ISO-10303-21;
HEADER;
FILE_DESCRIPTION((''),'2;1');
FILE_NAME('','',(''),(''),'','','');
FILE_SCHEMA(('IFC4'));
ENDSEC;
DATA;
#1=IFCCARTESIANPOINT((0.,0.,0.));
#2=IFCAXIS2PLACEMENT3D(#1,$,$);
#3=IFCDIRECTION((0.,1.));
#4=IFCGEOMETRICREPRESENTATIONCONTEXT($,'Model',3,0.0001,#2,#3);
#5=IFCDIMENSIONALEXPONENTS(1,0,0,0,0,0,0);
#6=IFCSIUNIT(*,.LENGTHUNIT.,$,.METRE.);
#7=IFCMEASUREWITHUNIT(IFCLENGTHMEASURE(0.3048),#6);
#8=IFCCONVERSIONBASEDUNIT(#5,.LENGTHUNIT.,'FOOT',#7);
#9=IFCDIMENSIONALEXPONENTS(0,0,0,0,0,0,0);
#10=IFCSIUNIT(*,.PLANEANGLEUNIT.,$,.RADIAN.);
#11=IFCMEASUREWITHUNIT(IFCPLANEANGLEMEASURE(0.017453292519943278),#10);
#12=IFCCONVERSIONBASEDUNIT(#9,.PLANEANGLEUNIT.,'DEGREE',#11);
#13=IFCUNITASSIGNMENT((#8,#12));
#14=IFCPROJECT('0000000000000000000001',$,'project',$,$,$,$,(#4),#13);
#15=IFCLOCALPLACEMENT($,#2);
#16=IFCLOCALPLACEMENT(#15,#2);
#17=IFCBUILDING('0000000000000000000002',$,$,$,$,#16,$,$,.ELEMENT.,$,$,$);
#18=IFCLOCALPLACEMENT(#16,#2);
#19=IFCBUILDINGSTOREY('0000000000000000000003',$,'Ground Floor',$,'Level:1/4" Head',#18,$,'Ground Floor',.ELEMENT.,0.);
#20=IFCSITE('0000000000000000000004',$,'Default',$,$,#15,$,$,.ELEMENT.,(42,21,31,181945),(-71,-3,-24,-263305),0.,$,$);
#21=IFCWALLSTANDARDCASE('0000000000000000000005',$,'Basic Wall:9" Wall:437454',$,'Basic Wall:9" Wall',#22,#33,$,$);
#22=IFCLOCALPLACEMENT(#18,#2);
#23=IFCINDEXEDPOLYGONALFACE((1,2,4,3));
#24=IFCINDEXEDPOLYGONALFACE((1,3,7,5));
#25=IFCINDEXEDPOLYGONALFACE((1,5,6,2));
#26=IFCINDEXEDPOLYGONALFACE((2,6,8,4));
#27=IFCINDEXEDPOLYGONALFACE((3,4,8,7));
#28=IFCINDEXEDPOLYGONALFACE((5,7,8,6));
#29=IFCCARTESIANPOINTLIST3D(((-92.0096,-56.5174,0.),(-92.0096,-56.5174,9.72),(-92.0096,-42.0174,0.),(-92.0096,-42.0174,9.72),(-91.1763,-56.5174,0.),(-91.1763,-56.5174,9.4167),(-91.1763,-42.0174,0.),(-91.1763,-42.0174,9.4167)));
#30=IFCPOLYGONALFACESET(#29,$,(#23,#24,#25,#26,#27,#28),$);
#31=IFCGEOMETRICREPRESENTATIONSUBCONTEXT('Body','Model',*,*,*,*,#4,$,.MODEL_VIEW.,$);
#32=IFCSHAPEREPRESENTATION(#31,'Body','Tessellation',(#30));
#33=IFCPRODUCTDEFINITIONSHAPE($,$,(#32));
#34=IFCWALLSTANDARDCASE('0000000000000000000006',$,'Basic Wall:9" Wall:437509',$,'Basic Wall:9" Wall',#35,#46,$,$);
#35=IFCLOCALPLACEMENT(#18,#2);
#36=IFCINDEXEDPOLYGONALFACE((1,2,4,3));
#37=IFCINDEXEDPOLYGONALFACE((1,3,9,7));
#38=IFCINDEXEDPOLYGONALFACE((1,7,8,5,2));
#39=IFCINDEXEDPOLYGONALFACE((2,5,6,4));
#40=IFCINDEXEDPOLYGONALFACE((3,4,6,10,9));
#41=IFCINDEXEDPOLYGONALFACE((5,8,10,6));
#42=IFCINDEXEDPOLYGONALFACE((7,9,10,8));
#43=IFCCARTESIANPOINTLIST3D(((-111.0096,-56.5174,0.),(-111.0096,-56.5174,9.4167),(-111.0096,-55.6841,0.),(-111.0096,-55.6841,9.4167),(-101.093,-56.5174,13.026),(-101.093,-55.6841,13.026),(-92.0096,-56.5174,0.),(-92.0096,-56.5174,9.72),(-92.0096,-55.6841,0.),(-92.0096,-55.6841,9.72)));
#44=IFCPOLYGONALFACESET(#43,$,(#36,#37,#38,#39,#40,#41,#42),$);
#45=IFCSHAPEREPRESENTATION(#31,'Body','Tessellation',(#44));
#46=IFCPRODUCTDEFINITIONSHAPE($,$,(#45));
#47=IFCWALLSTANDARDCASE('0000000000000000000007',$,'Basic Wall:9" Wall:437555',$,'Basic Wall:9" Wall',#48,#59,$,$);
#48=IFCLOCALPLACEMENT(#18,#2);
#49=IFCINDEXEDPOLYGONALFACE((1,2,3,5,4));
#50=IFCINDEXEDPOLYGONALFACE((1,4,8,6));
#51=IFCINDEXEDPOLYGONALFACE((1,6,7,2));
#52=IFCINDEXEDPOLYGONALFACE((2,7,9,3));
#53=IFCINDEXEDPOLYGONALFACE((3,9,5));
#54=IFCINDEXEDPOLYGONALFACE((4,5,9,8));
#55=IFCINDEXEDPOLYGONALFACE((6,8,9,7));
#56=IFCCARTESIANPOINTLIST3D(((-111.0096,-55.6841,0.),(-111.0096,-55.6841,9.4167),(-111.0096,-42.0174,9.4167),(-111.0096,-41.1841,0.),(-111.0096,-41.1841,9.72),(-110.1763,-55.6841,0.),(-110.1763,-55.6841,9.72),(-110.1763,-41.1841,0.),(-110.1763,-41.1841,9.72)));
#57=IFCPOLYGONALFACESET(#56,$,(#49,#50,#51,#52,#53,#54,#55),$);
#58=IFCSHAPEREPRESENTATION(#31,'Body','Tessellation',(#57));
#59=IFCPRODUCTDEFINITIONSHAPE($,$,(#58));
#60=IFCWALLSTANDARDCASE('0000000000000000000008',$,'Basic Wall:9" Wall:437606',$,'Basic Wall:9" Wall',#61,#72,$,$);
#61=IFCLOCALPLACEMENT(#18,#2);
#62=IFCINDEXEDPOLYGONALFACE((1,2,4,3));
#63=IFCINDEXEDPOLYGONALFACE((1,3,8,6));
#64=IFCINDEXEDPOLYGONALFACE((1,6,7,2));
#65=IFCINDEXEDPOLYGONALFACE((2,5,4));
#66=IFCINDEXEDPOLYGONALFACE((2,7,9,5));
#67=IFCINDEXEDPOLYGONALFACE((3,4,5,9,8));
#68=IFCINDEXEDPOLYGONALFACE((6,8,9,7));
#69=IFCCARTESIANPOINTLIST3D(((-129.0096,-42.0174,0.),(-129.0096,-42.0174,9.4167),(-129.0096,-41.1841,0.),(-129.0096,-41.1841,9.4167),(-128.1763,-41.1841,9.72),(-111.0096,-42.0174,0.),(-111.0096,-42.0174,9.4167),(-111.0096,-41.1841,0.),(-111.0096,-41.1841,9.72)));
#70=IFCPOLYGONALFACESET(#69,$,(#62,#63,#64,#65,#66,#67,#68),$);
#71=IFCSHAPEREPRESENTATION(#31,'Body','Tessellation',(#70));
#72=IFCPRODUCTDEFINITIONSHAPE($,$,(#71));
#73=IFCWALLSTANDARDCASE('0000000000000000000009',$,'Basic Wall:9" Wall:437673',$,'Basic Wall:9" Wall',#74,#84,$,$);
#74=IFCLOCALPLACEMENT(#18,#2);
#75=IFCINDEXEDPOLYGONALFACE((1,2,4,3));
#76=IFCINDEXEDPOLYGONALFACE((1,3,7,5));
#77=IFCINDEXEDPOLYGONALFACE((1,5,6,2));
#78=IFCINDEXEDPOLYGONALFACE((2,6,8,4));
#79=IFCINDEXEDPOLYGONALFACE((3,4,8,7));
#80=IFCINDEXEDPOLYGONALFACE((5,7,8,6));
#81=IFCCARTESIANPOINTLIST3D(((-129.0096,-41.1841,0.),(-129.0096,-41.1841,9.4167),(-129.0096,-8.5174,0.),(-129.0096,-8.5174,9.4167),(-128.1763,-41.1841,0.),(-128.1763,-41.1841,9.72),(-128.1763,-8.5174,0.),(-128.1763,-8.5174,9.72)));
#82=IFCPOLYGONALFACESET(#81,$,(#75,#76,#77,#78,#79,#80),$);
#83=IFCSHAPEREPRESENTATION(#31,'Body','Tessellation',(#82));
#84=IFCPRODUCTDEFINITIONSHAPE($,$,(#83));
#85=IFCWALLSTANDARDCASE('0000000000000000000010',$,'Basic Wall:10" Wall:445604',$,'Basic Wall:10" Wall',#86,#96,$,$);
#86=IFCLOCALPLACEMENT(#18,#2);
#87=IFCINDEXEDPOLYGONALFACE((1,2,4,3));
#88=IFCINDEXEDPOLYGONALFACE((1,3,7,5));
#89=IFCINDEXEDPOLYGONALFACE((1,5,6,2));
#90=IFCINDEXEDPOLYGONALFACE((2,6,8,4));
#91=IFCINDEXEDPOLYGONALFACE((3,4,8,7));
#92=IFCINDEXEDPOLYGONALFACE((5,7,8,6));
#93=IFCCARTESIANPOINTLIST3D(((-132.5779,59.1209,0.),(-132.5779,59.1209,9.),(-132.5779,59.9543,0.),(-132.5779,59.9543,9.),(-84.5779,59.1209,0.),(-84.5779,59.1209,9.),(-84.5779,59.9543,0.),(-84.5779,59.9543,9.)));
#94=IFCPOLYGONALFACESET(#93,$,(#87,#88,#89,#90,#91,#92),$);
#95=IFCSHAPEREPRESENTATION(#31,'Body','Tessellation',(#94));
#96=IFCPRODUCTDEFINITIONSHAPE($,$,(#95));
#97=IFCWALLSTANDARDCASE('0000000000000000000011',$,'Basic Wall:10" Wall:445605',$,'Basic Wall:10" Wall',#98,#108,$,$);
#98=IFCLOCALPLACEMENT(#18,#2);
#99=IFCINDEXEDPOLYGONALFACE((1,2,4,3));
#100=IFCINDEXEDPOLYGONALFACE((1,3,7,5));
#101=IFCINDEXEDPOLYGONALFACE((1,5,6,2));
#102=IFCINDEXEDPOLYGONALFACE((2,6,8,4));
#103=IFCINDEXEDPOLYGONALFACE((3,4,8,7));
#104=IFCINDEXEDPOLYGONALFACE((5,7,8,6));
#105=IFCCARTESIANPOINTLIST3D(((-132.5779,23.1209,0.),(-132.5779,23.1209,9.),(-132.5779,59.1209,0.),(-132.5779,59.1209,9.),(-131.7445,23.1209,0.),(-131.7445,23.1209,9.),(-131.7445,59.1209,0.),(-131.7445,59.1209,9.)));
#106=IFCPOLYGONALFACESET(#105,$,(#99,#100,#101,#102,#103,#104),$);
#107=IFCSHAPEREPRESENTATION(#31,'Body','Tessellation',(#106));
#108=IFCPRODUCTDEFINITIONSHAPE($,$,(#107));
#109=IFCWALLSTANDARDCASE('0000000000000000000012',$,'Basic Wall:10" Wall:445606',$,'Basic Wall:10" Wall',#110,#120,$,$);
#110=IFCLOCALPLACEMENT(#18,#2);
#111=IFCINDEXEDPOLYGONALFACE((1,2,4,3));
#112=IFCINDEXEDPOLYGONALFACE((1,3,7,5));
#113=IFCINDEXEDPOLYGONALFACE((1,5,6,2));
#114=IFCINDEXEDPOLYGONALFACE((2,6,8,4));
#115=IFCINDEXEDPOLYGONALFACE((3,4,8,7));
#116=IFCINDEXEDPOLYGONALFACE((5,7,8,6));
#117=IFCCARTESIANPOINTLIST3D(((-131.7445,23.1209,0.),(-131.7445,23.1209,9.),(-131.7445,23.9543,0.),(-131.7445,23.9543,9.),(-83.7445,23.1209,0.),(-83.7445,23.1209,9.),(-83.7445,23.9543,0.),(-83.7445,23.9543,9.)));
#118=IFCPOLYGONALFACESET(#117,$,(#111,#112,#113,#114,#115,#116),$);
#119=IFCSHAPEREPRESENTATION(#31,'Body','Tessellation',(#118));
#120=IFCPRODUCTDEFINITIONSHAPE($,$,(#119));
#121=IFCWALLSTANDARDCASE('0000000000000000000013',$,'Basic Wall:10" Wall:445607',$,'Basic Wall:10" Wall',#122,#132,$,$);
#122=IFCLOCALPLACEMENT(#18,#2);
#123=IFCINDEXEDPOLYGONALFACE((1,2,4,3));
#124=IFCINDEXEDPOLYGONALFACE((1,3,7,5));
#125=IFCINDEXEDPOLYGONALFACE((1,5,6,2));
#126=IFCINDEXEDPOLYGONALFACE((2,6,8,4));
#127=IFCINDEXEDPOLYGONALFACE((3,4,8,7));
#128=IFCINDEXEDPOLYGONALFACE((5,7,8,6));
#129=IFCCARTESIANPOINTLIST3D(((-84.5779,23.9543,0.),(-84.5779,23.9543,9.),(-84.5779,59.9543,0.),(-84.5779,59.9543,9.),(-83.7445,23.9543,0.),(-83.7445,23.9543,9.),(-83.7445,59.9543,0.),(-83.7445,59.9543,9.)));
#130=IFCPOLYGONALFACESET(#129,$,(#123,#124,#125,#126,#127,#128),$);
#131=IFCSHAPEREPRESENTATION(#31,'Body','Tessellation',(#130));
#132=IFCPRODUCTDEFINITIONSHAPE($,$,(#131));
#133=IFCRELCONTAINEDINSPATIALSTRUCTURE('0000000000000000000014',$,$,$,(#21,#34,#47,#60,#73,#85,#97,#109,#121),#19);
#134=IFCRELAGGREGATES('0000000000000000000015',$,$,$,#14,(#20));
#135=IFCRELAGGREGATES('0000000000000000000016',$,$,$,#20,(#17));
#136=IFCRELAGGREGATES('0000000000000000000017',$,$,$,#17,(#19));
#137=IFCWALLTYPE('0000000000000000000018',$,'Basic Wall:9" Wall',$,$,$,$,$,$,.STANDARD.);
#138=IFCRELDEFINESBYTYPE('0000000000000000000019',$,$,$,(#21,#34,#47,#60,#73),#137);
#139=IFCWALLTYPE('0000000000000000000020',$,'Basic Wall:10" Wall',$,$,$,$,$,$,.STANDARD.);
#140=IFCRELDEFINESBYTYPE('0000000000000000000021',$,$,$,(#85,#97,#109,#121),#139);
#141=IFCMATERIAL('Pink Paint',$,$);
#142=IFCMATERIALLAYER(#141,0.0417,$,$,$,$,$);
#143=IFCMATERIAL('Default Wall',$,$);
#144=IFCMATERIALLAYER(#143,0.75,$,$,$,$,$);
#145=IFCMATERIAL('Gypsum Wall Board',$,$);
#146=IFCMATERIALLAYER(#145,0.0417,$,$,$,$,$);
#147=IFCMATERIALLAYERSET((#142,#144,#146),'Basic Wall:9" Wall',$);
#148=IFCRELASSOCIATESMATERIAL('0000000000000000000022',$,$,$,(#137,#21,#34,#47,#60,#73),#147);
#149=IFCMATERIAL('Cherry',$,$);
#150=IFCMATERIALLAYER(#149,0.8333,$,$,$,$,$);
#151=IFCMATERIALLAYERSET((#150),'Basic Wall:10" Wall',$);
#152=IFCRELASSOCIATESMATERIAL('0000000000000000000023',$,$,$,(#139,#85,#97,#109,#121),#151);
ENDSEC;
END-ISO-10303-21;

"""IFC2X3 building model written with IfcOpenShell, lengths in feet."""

from ifc_helpers import new_model, entity, si_unit, converted_unit, direction, frame, frame_2d, origin, place, context, subcontext, project, spatial, polyline, rectangle, extrude, clip, bounded_halfspace, material, layer, layer_set, layer_usage, type_object, element, save


model = new_model("IFC2X3")

# Units and contexts
model_context = context("Model", 3, precision=0.0001, world=origin(), true_north=direction((0.0, 1.0)))
body_context = subcontext(model_context, "Body", "Model", "MODEL_VIEW")
ifc_project = project(units=[converted_unit("LENGTHUNIT", "FOOT", entity("IfcLengthMeasure", 0.3048), si_unit("LENGTHUNIT", "METRE"), dimensions=[1, 0, 0, 0, 0, 0, 0]), converted_unit("PLANEANGLEUNIT", "DEGREE", entity("IfcPlaneAngleMeasure", 0.017453292519943278), si_unit("PLANEANGLEUNIT", "RADIAN"), dimensions=[0, 0, 0, 0, 0, 0, 0])], contexts=[model_context])

# Site, building, storey
site_placement = place(None, origin())
site = spatial("IfcSite", under=ifc_project, at=site_placement, Name="Default", CompositionType="ELEMENT", RefLatitude=(42, 21, 31, 181945), RefLongitude=(-71, -3, -24, -263305), RefElevation=0.0)
building_placement = place(site_placement, origin())
building = spatial("IfcBuilding", under=site, at=building_placement, CompositionType="ELEMENT")
storey_placement = place(building_placement, origin())
storey = spatial("IfcBuildingStorey", under=building, at=storey_placement, Name="Ground Floor", ObjectType="Level:1/4\" Head", LongName="Ground Floor", CompositionType="ELEMENT", Elevation=0.0)

# Walls
ifc_material_1 = material(Name="Pink Paint")
ifc_layer_1 = layer(ifc_material_1, 0.0417)
ifc_material_2 = material(Name="Default Wall")
ifc_layer_2 = layer(ifc_material_2, 0.75)
ifc_material_3 = material(Name="Gypsum Wall Board")
ifc_layer_3 = layer(ifc_material_3, 0.0417)
ifc_layer_set_1 = layer_set([ifc_layer_1, ifc_layer_2, ifc_layer_3], Name="Basic Wall:9\" Wall")
ifc_layer_usage_1 = layer_usage(ifc_layer_set_1, "AXIS2", "NEGATIVE", 0.4167)
wall_type_1 = type_object("IfcWallType", Name="Basic Wall:9\" Wall", PredefinedType="STANDARD", material=ifc_layer_set_1)
wall_1_placement = place(storey_placement, frame((-91.593, -42.0174, 0.0), z_axis=(0.0, 0.0, 1.0), x_axis=(0.0, -1.0, 0.0)))
element("IfcWallStandardCase", 1, at=wall_1_placement, inside=storey, type_object=wall_type_1, material=ifc_layer_usage_1, Name="Basic Wall:9\" Wall:437454", ObjectType="Basic Wall:9\" Wall", context=body_context, shape_type="Clipping", body=[
    clip(extrude(rectangle(XDim=14.5, YDim=0.8333, at=frame_2d((7.25, 0.0), x_axis=(-1.0, 0.0))), origin(), (0.0, 0.0, 1.0), 9.72), bounded_halfspace(frame((0.0, -0.4167, 9.72), z_axis=(0.0, 0.34202, 0.939693), x_axis=(-1.0, 0.0, 0.0)), False, frame((0.0, -0.4167, 9.72)), polyline([(0.0, 0.0), (13.6667, 0.0), (14.5, 0.0), (14.5, 0.8333), (0.0, 0.8333), (0.0, 0.0)]))),
])
wall_2_placement = place(storey_placement, frame((-92.0096, -56.1008, 0.0), z_axis=(0.0, 0.0, 1.0), x_axis=(-1.0, 0.0, 0.0)))
element("IfcWallStandardCase", 2, at=wall_2_placement, inside=storey, type_object=wall_type_1, material=ifc_layer_usage_1, Name="Basic Wall:9\" Wall:437509", ObjectType="Basic Wall:9\" Wall", context=body_context, shape_type="Clipping", body=[
    clip(clip(extrude(rectangle(XDim=19.0, YDim=0.8333, at=frame_2d((9.5, 0.0), x_axis=(-1.0, 0.0))), origin(), (0.0, 0.0, 1.0), 13.026), bounded_halfspace(frame((9.0833, -0.4167, 13.026), z_axis=(0.34202, 0.0, 0.939693), x_axis=(0.0, 1.0, 0.0)), False, frame((9.0833, -0.4167, 13.026)), polyline([(0.0, 0.0), (9.0833, 0.0), (9.9167, 0.0), (9.9167, 0.8333), (0.0, 0.8333), (0.0, 0.0)]))), bounded_halfspace(frame((0.0, -0.4167, 9.72), z_axis=(-0.34202, 0.0, 0.939693), x_axis=(0.0, -1.0, 0.0)), False, frame((0.0, -0.4167, 9.72)), polyline([(0.0, 0.0), (9.0833, 0.0), (9.0833, 0.8333), (0.0, 0.8333), (0.0, 0.0)]))),
])
wall_3_placement = place(storey_placement, frame((-110.593, -55.6841, 0.0), z_axis=(0.0, 0.0, 1.0), x_axis=(0.0, 1.0, 0.0)))
element("IfcWallStandardCase", 3, at=wall_3_placement, inside=storey, type_object=wall_type_1, material=ifc_layer_usage_1, Name="Basic Wall:9\" Wall:437555", ObjectType="Basic Wall:9\" Wall", context=body_context, shape_type="Clipping", body=[
    clip(clip(extrude(rectangle(XDim=14.5, YDim=0.8333, at=frame_2d((7.25, 0.0), x_axis=(-1.0, 0.0))), origin(), (0.0, 0.0, 1.0), 9.72), bounded_halfspace(frame((0.0, -0.4167, 9.72), z_axis=(0.0, 0.34202, 0.939693), x_axis=(-1.0, 0.0, 0.0)), False, frame((0.0, -0.4167, 9.72)), polyline([(0.0, 0.0), (14.5, 0.0), (13.6667, 0.8333), (0.0, 0.8333), (0.0, 0.0)]))), bounded_halfspace(frame((14.5, -0.4167, 9.72), z_axis=(-0.34202, 0.0, 0.939693), x_axis=(0.0, -1.0, 0.0)), False, frame((14.5, -0.4167, 9.72)), polyline([(0.0, 0.0), (0.0, 0.8333), (-0.8333, 0.8333), (0.0, 0.0)]))),
])
wall_4_placement = place(storey_placement, frame((-111.0096, -41.6008, 0.0), z_axis=(0.0, 0.0, 1.0), x_axis=(-1.0, 0.0, 0.0)))
element("IfcWallStandardCase", 4, at=wall_4_placement, inside=storey, type_object=wall_type_1, material=ifc_layer_usage_1, Name="Basic Wall:9\" Wall:437606", ObjectType="Basic Wall:9\" Wall", context=body_context, shape_type="Clipping", body=[
    clip(clip(extrude(rectangle(XDim=18.0, YDim=0.8333, at=frame_2d((9.0, 0.0), x_axis=(-1.0, 0.0))), origin(), (0.0, 0.0, 1.0), 9.72), bounded_halfspace(frame((17.1667, -0.4167, 9.72), z_axis=(0.34202, 0.0, 0.939693), x_axis=(0.0, 1.0, 0.0)), False, frame((17.1667, -0.4167, 9.72)), polyline([(0.0, 0.0), (0.8333, 0.0), (0.8333, 0.8333), (0.0, 0.0)]))), bounded_halfspace(frame((0.0, -0.4167, 9.72), z_axis=(0.0, 0.34202, 0.939693), x_axis=(-1.0, 0.0, 0.0)), False, frame((0.0, -0.4167, 9.72)), polyline([(0.0, 0.0), (17.1667, 0.0), (18.0, 0.8333), (0.0, 0.8333), (0.0, 0.0)]))),
])
wall_5_placement = place(storey_placement, frame((-128.593, -41.1841, 0.0), z_axis=(0.0, 0.0, 1.0), x_axis=(0.0, 1.0, 0.0)))
element("IfcWallStandardCase", 5, at=wall_5_placement, inside=storey, type_object=wall_type_1, material=ifc_layer_usage_1, Name="Basic Wall:9\" Wall:437673", ObjectType="Basic Wall:9\" Wall", context=body_context, shape_type="Clipping", body=[
    clip(extrude(rectangle(XDim=32.6667, YDim=0.8333, at=frame_2d((16.3333, 0.0), x_axis=(-1.0, 0.0))), origin(), (0.0, 0.0, 1.0), 9.72), bounded_halfspace(frame((0.0, -0.4167, 9.72), z_axis=(0.0, 0.34202, 0.939693), x_axis=(-1.0, 0.0, 0.0)), False, frame((0.0, -0.4167, 9.72)), polyline([(0.0, 0.0), (32.6667, 0.0), (32.6667, 0.8333), (0.0, 0.8333), (0.0, 0.0)]))),
])
ifc_material_4 = material(Name="Cherry")
ifc_layer_4 = layer(ifc_material_4, 0.8333)
ifc_layer_set_2 = layer_set([ifc_layer_4], Name="Basic Wall:10\" Wall")
ifc_layer_usage_2 = layer_usage(ifc_layer_set_2, "AXIS2", "NEGATIVE", 0.4167)
wall_type_2 = type_object("IfcWallType", Name="Basic Wall:10\" Wall", PredefinedType="STANDARD", material=ifc_layer_set_2)
wall_6_placement = place(storey_placement, frame((-132.5779, 59.5376, 0.0)))
element("IfcWallStandardCase", 6, at=wall_6_placement, inside=storey, type_object=wall_type_2, material=ifc_layer_usage_2, Name="Basic Wall:10\" Wall:445604", ObjectType="Basic Wall:10\" Wall", context=body_context, shape_type="SweptSolid", body=[
    extrude(rectangle(XDim=48.0, YDim=0.8333, at=frame_2d((24.0, 0.0), x_axis=(-1.0, 0.0))), origin(), (0.0, 0.0, 1.0), 9.0),
])
wall_7_placement = place(storey_placement, frame((-132.1612, 23.1209, 0.0), z_axis=(0.0, 0.0, 1.0), x_axis=(0.0, 1.0, 0.0)))
element("IfcWallStandardCase", 7, at=wall_7_placement, inside=storey, type_object=wall_type_2, material=ifc_layer_usage_2, Name="Basic Wall:10\" Wall:445605", ObjectType="Basic Wall:10\" Wall", context=body_context, shape_type="SweptSolid", body=[
    extrude(rectangle(XDim=36.0, YDim=0.8333, at=frame_2d((18.0, 0.0), x_axis=(-1.0, 0.0))), origin(), (0.0, 0.0, 1.0), 9.0),
])
wall_8_placement = place(storey_placement, frame((-83.7445, 23.5376, 0.0), z_axis=(0.0, 0.0, 1.0), x_axis=(-1.0, 0.0, 0.0)))
element("IfcWallStandardCase", 8, at=wall_8_placement, inside=storey, type_object=wall_type_2, material=ifc_layer_usage_2, Name="Basic Wall:10\" Wall:445606", ObjectType="Basic Wall:10\" Wall", context=body_context, shape_type="SweptSolid", body=[
    extrude(rectangle(XDim=48.0, YDim=0.8333, at=frame_2d((24.0, 0.0), x_axis=(-1.0, 0.0))), origin(), (0.0, 0.0, 1.0), 9.0),
])
wall_9_placement = place(storey_placement, frame((-84.1612, 59.9543, 0.0), z_axis=(0.0, 0.0, 1.0), x_axis=(0.0, -1.0, 0.0)))
element("IfcWallStandardCase", 9, at=wall_9_placement, inside=storey, type_object=wall_type_2, material=ifc_layer_usage_2, Name="Basic Wall:10\" Wall:445607", ObjectType="Basic Wall:10\" Wall", context=body_context, shape_type="SweptSolid", body=[
    extrude(rectangle(XDim=36.0, YDim=0.8333, at=frame_2d((18.0, 0.0), x_axis=(-1.0, 0.0))), origin(), (0.0, 0.0, 1.0), 9.0),
])

save(model, "model.ifc")
